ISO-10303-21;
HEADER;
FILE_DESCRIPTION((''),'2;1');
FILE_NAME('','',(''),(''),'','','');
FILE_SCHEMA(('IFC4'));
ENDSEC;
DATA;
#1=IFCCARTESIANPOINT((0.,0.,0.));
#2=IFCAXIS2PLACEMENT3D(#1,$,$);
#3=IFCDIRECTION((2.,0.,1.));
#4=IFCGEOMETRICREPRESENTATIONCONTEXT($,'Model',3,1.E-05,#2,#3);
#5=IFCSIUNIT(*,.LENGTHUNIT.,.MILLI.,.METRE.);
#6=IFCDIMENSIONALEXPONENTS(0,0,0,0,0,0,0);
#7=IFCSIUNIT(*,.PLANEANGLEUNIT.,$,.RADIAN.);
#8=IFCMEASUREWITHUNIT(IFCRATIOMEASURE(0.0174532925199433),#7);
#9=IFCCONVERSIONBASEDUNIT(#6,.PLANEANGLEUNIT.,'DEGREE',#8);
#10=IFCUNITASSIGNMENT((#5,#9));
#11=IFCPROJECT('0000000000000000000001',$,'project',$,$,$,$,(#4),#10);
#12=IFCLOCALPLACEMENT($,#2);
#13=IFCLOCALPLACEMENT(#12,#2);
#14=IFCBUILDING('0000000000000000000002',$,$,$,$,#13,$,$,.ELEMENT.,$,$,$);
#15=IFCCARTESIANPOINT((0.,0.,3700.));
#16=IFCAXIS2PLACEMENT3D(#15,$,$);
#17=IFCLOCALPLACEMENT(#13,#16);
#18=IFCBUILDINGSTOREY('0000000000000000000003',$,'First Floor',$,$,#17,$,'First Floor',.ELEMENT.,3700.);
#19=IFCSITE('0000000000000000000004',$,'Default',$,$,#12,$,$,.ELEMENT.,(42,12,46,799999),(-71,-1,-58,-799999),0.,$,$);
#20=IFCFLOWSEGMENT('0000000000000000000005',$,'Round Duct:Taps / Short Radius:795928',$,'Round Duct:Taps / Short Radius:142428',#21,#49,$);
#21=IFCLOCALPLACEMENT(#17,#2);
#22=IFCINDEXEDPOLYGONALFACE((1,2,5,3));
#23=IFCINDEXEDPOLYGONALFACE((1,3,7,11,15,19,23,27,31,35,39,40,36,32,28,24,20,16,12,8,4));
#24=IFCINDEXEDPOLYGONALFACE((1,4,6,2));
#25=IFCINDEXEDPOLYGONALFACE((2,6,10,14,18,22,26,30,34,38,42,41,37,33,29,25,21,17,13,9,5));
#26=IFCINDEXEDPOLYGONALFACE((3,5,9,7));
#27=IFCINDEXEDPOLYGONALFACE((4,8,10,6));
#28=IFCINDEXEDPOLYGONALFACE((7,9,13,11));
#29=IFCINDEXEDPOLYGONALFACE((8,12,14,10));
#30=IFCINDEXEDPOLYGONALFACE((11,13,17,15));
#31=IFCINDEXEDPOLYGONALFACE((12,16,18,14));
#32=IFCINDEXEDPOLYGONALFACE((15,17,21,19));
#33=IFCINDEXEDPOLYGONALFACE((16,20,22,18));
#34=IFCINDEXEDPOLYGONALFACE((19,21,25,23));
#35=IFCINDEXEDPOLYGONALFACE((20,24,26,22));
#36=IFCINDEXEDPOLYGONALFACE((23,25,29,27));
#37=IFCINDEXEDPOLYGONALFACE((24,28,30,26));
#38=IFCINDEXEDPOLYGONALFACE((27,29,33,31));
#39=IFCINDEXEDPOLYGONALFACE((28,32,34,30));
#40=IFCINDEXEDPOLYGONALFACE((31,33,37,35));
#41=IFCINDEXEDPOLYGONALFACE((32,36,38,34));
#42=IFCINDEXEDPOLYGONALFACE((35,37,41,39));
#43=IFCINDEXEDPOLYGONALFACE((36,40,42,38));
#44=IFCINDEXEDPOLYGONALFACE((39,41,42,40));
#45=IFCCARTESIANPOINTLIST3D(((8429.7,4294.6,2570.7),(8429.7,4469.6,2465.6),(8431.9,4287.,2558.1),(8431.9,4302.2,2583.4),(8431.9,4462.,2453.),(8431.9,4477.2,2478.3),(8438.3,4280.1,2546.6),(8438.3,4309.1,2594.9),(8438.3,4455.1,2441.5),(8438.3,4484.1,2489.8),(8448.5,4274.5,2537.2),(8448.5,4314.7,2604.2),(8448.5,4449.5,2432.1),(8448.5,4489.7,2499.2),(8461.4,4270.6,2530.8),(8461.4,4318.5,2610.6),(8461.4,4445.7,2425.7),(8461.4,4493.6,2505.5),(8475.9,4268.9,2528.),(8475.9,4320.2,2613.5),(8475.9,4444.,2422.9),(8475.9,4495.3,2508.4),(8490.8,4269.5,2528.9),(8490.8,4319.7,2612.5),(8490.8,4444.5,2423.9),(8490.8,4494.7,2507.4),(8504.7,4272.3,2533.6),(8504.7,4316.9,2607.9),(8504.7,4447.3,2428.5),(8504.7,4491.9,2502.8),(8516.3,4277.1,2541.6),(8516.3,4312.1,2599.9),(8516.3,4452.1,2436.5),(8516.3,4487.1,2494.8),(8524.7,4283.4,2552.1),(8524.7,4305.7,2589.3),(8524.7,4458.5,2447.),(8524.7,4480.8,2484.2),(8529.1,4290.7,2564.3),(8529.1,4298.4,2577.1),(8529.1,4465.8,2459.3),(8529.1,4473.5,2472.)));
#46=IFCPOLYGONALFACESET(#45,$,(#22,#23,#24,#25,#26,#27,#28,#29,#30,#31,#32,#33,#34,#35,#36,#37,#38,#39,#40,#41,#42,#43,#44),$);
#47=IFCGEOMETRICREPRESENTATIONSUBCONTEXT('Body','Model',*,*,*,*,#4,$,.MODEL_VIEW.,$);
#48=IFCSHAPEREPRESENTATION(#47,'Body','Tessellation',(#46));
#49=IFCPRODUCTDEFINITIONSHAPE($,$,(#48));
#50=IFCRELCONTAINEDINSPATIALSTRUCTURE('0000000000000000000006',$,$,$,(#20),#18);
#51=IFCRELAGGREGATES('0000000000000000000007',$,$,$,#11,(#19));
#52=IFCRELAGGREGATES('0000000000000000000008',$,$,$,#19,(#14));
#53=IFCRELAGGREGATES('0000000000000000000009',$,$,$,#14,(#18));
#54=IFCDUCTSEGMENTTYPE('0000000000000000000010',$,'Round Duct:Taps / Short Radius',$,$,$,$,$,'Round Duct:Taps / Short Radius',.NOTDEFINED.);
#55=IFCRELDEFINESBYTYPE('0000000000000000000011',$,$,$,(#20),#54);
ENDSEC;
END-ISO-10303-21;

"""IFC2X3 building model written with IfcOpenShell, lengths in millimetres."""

from ifc_helpers import new_model, entity, si_unit, converted_unit, direction, frame, frame_2d, origin, place, context, subcontext, project, spatial, circle, extrude, type_object, element, save


model = new_model("IFC2X3")

# Units and contexts
model_context = context("Model", 3, precision=1e-05, world=origin(), true_north=direction((2.0, 0.0, 1.0)))
body_context = subcontext(model_context, "Body", "Model", "MODEL_VIEW")
ifc_project = project(units=[si_unit("LENGTHUNIT", "METRE", prefix="MILLI"), converted_unit("PLANEANGLEUNIT", "DEGREE", entity("IfcRatioMeasure", 0.0174532925199433), si_unit("PLANEANGLEUNIT", "RADIAN"), dimensions=[0, 0, 0, 0, 0, 0, 0])], contexts=[model_context])

# Site, building, storey
site_placement = place(None, origin())
site = spatial("IfcSite", under=ifc_project, at=site_placement, Name="Default", CompositionType="ELEMENT", RefLatitude=(42, 12, 46, 799999), RefLongitude=(-71, -1, -58, -799999), RefElevation=0.0)
building_placement = place(site_placement, origin())
building = spatial("IfcBuilding", under=site, at=building_placement, CompositionType="ELEMENT")
storey_placement = place(building_placement, frame((0.0, 0.0, 3700.0)))
storey = spatial("IfcBuildingStorey", under=building, at=storey_placement, Name="First Floor", LongName="First Floor", CompositionType="ELEMENT", Elevation=3700.0)

# Flow segment
duct_segment_type_1 = type_object("IfcDuctSegmentType", Name="Round Duct:Taps / Short Radius", ElementType="Round Duct:Taps / Short Radius", PredefinedType="NOTDEFINED")
flow_segment_1_placement = place(storey_placement, origin())
element("IfcFlowSegment", 1, at=flow_segment_1_placement, inside=storey, type_object=duct_segment_type_1, Name="Round Duct:Taps / Short Radius:795928", ObjectType="Round Duct:Taps / Short Radius:142428", context=body_context, shape_type="SweptSolid", body=[
    extrude(circle(Radius=50.0, at=frame_2d((0.0, 0.0), x_axis=(1.0, 0.0))), frame((8479.7, 4294.6, 2570.7), z_axis=(0.0, 0.85734, -0.51475), x_axis=(-1.0, 0.0, 0.0)), (0.0, 0.0, 1.0), 204.2),
])

save(model, "model.ifc")
